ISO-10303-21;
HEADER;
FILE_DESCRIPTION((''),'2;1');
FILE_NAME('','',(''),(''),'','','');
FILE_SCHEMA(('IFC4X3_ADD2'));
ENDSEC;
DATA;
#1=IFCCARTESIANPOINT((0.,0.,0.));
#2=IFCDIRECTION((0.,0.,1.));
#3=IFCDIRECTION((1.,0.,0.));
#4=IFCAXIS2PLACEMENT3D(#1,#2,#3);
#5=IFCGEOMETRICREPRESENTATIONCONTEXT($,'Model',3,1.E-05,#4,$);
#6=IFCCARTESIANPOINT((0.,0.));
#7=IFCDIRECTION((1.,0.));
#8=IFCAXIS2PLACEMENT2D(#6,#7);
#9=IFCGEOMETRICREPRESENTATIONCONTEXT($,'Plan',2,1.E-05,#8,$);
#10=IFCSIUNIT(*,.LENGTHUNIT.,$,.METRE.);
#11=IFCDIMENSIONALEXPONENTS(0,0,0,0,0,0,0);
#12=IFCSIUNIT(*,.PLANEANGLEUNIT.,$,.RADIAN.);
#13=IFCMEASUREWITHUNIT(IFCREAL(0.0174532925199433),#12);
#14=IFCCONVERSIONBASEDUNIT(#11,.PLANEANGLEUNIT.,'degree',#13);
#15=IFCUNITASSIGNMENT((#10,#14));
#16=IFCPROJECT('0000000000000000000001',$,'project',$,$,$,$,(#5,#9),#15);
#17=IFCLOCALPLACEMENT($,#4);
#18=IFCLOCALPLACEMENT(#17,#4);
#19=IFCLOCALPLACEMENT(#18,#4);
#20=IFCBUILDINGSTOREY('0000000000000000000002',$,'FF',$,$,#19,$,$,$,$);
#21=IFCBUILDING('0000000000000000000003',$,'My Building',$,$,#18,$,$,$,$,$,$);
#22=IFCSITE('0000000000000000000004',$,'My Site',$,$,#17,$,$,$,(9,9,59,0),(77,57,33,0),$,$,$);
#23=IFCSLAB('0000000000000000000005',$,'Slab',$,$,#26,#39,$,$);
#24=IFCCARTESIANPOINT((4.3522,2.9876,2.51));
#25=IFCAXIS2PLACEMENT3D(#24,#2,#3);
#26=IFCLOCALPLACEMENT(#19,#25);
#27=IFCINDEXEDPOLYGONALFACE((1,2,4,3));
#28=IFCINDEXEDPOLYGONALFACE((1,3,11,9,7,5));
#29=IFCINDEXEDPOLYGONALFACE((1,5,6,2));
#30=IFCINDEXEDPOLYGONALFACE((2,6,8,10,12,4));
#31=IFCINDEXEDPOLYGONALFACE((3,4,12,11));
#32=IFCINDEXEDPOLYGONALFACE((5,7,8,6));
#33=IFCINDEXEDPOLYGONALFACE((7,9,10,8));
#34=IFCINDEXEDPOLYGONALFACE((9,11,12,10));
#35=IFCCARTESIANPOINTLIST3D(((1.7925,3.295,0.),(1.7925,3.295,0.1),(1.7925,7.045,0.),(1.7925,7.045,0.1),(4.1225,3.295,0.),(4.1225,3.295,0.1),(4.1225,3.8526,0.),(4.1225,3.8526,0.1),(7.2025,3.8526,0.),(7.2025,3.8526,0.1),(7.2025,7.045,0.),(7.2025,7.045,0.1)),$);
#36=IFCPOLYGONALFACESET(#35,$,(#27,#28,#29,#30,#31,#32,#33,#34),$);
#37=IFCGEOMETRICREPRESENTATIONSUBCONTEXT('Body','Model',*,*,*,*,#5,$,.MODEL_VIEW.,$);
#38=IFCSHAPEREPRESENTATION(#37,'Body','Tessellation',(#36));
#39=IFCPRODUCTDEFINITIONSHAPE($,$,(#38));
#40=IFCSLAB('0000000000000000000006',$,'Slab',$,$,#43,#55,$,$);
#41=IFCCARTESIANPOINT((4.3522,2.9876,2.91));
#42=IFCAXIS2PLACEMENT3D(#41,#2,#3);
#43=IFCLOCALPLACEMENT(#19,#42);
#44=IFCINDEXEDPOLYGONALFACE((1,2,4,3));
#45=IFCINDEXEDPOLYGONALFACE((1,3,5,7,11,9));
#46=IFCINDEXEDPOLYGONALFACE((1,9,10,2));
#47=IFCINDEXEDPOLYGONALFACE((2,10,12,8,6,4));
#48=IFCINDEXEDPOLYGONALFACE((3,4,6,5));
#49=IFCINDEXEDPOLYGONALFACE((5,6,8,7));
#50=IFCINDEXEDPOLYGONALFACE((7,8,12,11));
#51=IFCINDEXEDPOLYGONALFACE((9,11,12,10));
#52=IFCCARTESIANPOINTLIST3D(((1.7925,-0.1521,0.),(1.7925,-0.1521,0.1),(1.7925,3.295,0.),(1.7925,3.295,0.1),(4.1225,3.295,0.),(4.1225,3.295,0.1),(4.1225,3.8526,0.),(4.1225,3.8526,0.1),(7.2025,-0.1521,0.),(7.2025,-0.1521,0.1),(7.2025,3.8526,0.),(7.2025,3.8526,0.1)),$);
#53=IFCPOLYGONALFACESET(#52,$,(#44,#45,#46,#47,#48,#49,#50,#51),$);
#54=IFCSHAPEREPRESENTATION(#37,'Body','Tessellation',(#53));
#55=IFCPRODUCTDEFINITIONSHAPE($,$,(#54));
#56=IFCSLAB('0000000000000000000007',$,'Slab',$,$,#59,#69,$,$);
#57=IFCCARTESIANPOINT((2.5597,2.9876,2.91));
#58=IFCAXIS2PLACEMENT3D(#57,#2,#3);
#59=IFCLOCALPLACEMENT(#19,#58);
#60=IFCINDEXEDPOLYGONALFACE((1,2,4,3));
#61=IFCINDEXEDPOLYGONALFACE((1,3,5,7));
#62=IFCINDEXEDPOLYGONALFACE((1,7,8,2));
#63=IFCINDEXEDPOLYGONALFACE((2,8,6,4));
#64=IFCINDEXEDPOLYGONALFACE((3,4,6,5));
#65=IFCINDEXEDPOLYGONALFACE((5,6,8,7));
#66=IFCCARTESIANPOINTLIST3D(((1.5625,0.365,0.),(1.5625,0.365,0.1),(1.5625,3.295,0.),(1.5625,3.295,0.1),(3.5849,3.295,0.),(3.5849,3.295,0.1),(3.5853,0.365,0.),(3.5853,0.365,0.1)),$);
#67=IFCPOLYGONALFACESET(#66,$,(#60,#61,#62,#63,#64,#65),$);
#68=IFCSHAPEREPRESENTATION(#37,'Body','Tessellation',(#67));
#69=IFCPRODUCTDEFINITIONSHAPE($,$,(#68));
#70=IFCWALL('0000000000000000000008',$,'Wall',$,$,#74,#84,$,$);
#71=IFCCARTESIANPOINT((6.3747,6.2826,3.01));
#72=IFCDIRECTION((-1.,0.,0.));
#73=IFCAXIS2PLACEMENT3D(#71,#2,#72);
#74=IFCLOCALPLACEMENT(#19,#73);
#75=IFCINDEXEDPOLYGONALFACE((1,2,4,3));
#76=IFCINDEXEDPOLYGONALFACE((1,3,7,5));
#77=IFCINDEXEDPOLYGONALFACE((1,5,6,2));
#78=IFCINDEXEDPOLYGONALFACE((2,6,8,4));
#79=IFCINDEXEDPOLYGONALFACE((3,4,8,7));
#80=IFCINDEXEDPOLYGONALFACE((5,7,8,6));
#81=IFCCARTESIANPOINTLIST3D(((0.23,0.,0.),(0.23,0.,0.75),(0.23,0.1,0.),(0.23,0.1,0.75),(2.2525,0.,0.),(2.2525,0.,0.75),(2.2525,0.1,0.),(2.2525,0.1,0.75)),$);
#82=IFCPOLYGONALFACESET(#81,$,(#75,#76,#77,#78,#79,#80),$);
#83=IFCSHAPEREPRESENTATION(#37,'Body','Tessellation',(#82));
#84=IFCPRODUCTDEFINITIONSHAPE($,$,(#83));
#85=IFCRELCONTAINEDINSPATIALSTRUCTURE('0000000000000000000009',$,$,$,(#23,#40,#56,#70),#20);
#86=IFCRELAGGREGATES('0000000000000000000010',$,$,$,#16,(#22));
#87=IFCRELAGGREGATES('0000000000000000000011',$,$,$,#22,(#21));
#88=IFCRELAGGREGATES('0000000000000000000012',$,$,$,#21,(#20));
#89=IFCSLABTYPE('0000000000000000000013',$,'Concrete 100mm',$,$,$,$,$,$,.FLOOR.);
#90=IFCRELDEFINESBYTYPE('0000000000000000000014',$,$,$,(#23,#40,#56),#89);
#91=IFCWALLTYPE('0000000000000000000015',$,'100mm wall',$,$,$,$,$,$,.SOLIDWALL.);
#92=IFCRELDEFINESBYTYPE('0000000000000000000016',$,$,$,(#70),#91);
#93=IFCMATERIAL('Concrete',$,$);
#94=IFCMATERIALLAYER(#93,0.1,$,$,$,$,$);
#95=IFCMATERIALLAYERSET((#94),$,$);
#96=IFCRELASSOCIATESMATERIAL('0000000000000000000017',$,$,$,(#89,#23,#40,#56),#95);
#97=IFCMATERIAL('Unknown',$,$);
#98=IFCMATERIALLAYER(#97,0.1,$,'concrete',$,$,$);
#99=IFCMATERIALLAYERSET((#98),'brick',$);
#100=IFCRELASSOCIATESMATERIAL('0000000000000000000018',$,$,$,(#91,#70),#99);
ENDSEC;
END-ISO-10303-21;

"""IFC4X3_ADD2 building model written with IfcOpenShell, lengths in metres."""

from ifc_helpers import new_model, entity, si_unit, converted_unit, frame, origin_with_axes, origin_2d_with_axis, place, context, subcontext, project, spatial, line, indexed_curve, outline, extrude, material, layer, layer_set, layer_usage, type_object, element, save


model = new_model("IFC4X3_ADD2")

# Units and contexts
model_context = context("Model", 3, precision=1e-05, world=origin_with_axes())
plan_context = context("Plan", 2, precision=1e-05, world=origin_2d_with_axis())
body_context_1 = subcontext(model_context, "Body", "Model", "MODEL_VIEW")
ifc_project = project(units=[si_unit("LENGTHUNIT", "METRE"), converted_unit("PLANEANGLEUNIT", "degree", entity("IfcReal", 0.0174532925199433), si_unit("PLANEANGLEUNIT", "RADIAN"), dimensions=[0, 0, 0, 0, 0, 0, 0])], contexts=[model_context, plan_context])

# Site, building, storey
site_placement = place(None, origin_with_axes())
site = spatial("IfcSite", under=ifc_project, at=site_placement, Name="My Site", RefLatitude=(9, 9, 59, 0), RefLongitude=(77, 57, 33, 0))
building_placement = place(site_placement, origin_with_axes())
building = spatial("IfcBuilding", under=site, at=building_placement, Name="My Building")
storey_placement = place(building_placement, origin_with_axes())
storey = spatial("IfcBuildingStorey", under=building, at=storey_placement, Name="FF")

# Shared definitions
ifc_material_1 = material(Name="Unknown")

# Slabs
ifc_material_2 = material(Name="Concrete")
ifc_layer_1 = layer(ifc_material_2, 0.1)
ifc_layer_set_1 = layer_set([ifc_layer_1])
ifc_layer_usage_1 = layer_usage(ifc_layer_set_1, "AXIS3", "POSITIVE", 0.0)
slab_type = type_object("IfcSlabType", Name="Concrete 100mm", PredefinedType="FLOOR", material=ifc_layer_set_1)
slab_1_placement = place(storey_placement, frame((4.3522, 2.9876, 2.51), z_axis=(0.0, 0.0, 1.0), x_axis=(1.0, 0.0, 0.0)))
element("IfcSlab", 1, at=slab_1_placement, inside=storey, type_object=slab_type, material=ifc_layer_usage_1, Name="Slab", context=body_context_1, shape_type="SweptSolid", body=[
    extrude(outline(indexed_curve([(7.2025, 3.8526), (4.1225, 3.8526), (4.1225, 3.295), (1.7925, 3.295), (1.7925, 7.045), (7.2025, 7.045), (7.2025, 3.8526)])), origin_with_axes(), (0.0, 0.0, 1.0), 0.1),
])
ifc_layer_usage_2 = layer_usage(ifc_layer_set_1, "AXIS3", "POSITIVE", 0.0)
slab_2_placement = place(storey_placement, frame((4.3522, 2.9876, 2.91), z_axis=(0.0, 0.0, 1.0), x_axis=(1.0, 0.0, 0.0)))
element("IfcSlab", 2, at=slab_2_placement, inside=storey, type_object=slab_type, material=ifc_layer_usage_2, Name="Slab", context=body_context_1, shape_type="SweptSolid", body=[
    extrude(outline(indexed_curve([(7.2025, -0.1521), (1.7925, -0.1521), (1.7925, 3.295), (4.1225, 3.295), (4.1225, 3.8526), (7.2025, 3.8526), (7.2025, -0.1521)])), origin_with_axes(), (0.0, 0.0, 1.0), 0.1),
])
ifc_layer_usage_3 = layer_usage(ifc_layer_set_1, "AXIS3", "POSITIVE", 0.0)
slab_3_placement = place(storey_placement, frame((2.5597, 2.9876, 2.91), z_axis=(0.0, 0.0, 1.0), x_axis=(1.0, 0.0, 0.0)))
element("IfcSlab", 3, at=slab_3_placement, inside=storey, type_object=slab_type, material=ifc_layer_usage_3, Name="Slab", context=body_context_1, shape_type="SweptSolid", body=[
    extrude(outline(indexed_curve([(1.5625, 0.365), (1.5625, 3.295), (3.5849, 3.295), (3.5853, 0.365), (1.5625, 0.365)])), origin_with_axes(), (0.0, 0.0, 1.0), 0.1),
])

# Wall
ifc_layer_2 = layer(ifc_material_1, 0.1, Name="concrete")
ifc_layer_set_2 = layer_set([ifc_layer_2], Name="brick")
wall_type_1 = type_object("IfcWallType", Name="100mm wall", PredefinedType="SOLIDWALL", material=ifc_layer_set_2)
ifc_layer_usage_4 = layer_usage(ifc_layer_set_2, "AXIS2", "POSITIVE", 0.0)
wall_1_placement = place(storey_placement, frame((6.3747, 6.2826, 3.01), z_axis=(0.0, 0.0, 1.0), x_axis=(-1.0, 0.0, 0.0)))
element("IfcWall", 4, at=wall_1_placement, inside=storey, type_object=wall_type_1, material=ifc_layer_usage_4, Name="Wall", context=body_context_1, shape_type="SweptSolid", body=[
    extrude(outline(indexed_curve([(0.23, 0.0), (0.23, 0.1), (2.2525, 0.1), (2.2525, 0.0)], segments=[line(1, 2, 3, 4, 1)])), origin_with_axes(), (0.0, 0.0, 1.0), 0.75),
])

save(model, "model.ifc")
